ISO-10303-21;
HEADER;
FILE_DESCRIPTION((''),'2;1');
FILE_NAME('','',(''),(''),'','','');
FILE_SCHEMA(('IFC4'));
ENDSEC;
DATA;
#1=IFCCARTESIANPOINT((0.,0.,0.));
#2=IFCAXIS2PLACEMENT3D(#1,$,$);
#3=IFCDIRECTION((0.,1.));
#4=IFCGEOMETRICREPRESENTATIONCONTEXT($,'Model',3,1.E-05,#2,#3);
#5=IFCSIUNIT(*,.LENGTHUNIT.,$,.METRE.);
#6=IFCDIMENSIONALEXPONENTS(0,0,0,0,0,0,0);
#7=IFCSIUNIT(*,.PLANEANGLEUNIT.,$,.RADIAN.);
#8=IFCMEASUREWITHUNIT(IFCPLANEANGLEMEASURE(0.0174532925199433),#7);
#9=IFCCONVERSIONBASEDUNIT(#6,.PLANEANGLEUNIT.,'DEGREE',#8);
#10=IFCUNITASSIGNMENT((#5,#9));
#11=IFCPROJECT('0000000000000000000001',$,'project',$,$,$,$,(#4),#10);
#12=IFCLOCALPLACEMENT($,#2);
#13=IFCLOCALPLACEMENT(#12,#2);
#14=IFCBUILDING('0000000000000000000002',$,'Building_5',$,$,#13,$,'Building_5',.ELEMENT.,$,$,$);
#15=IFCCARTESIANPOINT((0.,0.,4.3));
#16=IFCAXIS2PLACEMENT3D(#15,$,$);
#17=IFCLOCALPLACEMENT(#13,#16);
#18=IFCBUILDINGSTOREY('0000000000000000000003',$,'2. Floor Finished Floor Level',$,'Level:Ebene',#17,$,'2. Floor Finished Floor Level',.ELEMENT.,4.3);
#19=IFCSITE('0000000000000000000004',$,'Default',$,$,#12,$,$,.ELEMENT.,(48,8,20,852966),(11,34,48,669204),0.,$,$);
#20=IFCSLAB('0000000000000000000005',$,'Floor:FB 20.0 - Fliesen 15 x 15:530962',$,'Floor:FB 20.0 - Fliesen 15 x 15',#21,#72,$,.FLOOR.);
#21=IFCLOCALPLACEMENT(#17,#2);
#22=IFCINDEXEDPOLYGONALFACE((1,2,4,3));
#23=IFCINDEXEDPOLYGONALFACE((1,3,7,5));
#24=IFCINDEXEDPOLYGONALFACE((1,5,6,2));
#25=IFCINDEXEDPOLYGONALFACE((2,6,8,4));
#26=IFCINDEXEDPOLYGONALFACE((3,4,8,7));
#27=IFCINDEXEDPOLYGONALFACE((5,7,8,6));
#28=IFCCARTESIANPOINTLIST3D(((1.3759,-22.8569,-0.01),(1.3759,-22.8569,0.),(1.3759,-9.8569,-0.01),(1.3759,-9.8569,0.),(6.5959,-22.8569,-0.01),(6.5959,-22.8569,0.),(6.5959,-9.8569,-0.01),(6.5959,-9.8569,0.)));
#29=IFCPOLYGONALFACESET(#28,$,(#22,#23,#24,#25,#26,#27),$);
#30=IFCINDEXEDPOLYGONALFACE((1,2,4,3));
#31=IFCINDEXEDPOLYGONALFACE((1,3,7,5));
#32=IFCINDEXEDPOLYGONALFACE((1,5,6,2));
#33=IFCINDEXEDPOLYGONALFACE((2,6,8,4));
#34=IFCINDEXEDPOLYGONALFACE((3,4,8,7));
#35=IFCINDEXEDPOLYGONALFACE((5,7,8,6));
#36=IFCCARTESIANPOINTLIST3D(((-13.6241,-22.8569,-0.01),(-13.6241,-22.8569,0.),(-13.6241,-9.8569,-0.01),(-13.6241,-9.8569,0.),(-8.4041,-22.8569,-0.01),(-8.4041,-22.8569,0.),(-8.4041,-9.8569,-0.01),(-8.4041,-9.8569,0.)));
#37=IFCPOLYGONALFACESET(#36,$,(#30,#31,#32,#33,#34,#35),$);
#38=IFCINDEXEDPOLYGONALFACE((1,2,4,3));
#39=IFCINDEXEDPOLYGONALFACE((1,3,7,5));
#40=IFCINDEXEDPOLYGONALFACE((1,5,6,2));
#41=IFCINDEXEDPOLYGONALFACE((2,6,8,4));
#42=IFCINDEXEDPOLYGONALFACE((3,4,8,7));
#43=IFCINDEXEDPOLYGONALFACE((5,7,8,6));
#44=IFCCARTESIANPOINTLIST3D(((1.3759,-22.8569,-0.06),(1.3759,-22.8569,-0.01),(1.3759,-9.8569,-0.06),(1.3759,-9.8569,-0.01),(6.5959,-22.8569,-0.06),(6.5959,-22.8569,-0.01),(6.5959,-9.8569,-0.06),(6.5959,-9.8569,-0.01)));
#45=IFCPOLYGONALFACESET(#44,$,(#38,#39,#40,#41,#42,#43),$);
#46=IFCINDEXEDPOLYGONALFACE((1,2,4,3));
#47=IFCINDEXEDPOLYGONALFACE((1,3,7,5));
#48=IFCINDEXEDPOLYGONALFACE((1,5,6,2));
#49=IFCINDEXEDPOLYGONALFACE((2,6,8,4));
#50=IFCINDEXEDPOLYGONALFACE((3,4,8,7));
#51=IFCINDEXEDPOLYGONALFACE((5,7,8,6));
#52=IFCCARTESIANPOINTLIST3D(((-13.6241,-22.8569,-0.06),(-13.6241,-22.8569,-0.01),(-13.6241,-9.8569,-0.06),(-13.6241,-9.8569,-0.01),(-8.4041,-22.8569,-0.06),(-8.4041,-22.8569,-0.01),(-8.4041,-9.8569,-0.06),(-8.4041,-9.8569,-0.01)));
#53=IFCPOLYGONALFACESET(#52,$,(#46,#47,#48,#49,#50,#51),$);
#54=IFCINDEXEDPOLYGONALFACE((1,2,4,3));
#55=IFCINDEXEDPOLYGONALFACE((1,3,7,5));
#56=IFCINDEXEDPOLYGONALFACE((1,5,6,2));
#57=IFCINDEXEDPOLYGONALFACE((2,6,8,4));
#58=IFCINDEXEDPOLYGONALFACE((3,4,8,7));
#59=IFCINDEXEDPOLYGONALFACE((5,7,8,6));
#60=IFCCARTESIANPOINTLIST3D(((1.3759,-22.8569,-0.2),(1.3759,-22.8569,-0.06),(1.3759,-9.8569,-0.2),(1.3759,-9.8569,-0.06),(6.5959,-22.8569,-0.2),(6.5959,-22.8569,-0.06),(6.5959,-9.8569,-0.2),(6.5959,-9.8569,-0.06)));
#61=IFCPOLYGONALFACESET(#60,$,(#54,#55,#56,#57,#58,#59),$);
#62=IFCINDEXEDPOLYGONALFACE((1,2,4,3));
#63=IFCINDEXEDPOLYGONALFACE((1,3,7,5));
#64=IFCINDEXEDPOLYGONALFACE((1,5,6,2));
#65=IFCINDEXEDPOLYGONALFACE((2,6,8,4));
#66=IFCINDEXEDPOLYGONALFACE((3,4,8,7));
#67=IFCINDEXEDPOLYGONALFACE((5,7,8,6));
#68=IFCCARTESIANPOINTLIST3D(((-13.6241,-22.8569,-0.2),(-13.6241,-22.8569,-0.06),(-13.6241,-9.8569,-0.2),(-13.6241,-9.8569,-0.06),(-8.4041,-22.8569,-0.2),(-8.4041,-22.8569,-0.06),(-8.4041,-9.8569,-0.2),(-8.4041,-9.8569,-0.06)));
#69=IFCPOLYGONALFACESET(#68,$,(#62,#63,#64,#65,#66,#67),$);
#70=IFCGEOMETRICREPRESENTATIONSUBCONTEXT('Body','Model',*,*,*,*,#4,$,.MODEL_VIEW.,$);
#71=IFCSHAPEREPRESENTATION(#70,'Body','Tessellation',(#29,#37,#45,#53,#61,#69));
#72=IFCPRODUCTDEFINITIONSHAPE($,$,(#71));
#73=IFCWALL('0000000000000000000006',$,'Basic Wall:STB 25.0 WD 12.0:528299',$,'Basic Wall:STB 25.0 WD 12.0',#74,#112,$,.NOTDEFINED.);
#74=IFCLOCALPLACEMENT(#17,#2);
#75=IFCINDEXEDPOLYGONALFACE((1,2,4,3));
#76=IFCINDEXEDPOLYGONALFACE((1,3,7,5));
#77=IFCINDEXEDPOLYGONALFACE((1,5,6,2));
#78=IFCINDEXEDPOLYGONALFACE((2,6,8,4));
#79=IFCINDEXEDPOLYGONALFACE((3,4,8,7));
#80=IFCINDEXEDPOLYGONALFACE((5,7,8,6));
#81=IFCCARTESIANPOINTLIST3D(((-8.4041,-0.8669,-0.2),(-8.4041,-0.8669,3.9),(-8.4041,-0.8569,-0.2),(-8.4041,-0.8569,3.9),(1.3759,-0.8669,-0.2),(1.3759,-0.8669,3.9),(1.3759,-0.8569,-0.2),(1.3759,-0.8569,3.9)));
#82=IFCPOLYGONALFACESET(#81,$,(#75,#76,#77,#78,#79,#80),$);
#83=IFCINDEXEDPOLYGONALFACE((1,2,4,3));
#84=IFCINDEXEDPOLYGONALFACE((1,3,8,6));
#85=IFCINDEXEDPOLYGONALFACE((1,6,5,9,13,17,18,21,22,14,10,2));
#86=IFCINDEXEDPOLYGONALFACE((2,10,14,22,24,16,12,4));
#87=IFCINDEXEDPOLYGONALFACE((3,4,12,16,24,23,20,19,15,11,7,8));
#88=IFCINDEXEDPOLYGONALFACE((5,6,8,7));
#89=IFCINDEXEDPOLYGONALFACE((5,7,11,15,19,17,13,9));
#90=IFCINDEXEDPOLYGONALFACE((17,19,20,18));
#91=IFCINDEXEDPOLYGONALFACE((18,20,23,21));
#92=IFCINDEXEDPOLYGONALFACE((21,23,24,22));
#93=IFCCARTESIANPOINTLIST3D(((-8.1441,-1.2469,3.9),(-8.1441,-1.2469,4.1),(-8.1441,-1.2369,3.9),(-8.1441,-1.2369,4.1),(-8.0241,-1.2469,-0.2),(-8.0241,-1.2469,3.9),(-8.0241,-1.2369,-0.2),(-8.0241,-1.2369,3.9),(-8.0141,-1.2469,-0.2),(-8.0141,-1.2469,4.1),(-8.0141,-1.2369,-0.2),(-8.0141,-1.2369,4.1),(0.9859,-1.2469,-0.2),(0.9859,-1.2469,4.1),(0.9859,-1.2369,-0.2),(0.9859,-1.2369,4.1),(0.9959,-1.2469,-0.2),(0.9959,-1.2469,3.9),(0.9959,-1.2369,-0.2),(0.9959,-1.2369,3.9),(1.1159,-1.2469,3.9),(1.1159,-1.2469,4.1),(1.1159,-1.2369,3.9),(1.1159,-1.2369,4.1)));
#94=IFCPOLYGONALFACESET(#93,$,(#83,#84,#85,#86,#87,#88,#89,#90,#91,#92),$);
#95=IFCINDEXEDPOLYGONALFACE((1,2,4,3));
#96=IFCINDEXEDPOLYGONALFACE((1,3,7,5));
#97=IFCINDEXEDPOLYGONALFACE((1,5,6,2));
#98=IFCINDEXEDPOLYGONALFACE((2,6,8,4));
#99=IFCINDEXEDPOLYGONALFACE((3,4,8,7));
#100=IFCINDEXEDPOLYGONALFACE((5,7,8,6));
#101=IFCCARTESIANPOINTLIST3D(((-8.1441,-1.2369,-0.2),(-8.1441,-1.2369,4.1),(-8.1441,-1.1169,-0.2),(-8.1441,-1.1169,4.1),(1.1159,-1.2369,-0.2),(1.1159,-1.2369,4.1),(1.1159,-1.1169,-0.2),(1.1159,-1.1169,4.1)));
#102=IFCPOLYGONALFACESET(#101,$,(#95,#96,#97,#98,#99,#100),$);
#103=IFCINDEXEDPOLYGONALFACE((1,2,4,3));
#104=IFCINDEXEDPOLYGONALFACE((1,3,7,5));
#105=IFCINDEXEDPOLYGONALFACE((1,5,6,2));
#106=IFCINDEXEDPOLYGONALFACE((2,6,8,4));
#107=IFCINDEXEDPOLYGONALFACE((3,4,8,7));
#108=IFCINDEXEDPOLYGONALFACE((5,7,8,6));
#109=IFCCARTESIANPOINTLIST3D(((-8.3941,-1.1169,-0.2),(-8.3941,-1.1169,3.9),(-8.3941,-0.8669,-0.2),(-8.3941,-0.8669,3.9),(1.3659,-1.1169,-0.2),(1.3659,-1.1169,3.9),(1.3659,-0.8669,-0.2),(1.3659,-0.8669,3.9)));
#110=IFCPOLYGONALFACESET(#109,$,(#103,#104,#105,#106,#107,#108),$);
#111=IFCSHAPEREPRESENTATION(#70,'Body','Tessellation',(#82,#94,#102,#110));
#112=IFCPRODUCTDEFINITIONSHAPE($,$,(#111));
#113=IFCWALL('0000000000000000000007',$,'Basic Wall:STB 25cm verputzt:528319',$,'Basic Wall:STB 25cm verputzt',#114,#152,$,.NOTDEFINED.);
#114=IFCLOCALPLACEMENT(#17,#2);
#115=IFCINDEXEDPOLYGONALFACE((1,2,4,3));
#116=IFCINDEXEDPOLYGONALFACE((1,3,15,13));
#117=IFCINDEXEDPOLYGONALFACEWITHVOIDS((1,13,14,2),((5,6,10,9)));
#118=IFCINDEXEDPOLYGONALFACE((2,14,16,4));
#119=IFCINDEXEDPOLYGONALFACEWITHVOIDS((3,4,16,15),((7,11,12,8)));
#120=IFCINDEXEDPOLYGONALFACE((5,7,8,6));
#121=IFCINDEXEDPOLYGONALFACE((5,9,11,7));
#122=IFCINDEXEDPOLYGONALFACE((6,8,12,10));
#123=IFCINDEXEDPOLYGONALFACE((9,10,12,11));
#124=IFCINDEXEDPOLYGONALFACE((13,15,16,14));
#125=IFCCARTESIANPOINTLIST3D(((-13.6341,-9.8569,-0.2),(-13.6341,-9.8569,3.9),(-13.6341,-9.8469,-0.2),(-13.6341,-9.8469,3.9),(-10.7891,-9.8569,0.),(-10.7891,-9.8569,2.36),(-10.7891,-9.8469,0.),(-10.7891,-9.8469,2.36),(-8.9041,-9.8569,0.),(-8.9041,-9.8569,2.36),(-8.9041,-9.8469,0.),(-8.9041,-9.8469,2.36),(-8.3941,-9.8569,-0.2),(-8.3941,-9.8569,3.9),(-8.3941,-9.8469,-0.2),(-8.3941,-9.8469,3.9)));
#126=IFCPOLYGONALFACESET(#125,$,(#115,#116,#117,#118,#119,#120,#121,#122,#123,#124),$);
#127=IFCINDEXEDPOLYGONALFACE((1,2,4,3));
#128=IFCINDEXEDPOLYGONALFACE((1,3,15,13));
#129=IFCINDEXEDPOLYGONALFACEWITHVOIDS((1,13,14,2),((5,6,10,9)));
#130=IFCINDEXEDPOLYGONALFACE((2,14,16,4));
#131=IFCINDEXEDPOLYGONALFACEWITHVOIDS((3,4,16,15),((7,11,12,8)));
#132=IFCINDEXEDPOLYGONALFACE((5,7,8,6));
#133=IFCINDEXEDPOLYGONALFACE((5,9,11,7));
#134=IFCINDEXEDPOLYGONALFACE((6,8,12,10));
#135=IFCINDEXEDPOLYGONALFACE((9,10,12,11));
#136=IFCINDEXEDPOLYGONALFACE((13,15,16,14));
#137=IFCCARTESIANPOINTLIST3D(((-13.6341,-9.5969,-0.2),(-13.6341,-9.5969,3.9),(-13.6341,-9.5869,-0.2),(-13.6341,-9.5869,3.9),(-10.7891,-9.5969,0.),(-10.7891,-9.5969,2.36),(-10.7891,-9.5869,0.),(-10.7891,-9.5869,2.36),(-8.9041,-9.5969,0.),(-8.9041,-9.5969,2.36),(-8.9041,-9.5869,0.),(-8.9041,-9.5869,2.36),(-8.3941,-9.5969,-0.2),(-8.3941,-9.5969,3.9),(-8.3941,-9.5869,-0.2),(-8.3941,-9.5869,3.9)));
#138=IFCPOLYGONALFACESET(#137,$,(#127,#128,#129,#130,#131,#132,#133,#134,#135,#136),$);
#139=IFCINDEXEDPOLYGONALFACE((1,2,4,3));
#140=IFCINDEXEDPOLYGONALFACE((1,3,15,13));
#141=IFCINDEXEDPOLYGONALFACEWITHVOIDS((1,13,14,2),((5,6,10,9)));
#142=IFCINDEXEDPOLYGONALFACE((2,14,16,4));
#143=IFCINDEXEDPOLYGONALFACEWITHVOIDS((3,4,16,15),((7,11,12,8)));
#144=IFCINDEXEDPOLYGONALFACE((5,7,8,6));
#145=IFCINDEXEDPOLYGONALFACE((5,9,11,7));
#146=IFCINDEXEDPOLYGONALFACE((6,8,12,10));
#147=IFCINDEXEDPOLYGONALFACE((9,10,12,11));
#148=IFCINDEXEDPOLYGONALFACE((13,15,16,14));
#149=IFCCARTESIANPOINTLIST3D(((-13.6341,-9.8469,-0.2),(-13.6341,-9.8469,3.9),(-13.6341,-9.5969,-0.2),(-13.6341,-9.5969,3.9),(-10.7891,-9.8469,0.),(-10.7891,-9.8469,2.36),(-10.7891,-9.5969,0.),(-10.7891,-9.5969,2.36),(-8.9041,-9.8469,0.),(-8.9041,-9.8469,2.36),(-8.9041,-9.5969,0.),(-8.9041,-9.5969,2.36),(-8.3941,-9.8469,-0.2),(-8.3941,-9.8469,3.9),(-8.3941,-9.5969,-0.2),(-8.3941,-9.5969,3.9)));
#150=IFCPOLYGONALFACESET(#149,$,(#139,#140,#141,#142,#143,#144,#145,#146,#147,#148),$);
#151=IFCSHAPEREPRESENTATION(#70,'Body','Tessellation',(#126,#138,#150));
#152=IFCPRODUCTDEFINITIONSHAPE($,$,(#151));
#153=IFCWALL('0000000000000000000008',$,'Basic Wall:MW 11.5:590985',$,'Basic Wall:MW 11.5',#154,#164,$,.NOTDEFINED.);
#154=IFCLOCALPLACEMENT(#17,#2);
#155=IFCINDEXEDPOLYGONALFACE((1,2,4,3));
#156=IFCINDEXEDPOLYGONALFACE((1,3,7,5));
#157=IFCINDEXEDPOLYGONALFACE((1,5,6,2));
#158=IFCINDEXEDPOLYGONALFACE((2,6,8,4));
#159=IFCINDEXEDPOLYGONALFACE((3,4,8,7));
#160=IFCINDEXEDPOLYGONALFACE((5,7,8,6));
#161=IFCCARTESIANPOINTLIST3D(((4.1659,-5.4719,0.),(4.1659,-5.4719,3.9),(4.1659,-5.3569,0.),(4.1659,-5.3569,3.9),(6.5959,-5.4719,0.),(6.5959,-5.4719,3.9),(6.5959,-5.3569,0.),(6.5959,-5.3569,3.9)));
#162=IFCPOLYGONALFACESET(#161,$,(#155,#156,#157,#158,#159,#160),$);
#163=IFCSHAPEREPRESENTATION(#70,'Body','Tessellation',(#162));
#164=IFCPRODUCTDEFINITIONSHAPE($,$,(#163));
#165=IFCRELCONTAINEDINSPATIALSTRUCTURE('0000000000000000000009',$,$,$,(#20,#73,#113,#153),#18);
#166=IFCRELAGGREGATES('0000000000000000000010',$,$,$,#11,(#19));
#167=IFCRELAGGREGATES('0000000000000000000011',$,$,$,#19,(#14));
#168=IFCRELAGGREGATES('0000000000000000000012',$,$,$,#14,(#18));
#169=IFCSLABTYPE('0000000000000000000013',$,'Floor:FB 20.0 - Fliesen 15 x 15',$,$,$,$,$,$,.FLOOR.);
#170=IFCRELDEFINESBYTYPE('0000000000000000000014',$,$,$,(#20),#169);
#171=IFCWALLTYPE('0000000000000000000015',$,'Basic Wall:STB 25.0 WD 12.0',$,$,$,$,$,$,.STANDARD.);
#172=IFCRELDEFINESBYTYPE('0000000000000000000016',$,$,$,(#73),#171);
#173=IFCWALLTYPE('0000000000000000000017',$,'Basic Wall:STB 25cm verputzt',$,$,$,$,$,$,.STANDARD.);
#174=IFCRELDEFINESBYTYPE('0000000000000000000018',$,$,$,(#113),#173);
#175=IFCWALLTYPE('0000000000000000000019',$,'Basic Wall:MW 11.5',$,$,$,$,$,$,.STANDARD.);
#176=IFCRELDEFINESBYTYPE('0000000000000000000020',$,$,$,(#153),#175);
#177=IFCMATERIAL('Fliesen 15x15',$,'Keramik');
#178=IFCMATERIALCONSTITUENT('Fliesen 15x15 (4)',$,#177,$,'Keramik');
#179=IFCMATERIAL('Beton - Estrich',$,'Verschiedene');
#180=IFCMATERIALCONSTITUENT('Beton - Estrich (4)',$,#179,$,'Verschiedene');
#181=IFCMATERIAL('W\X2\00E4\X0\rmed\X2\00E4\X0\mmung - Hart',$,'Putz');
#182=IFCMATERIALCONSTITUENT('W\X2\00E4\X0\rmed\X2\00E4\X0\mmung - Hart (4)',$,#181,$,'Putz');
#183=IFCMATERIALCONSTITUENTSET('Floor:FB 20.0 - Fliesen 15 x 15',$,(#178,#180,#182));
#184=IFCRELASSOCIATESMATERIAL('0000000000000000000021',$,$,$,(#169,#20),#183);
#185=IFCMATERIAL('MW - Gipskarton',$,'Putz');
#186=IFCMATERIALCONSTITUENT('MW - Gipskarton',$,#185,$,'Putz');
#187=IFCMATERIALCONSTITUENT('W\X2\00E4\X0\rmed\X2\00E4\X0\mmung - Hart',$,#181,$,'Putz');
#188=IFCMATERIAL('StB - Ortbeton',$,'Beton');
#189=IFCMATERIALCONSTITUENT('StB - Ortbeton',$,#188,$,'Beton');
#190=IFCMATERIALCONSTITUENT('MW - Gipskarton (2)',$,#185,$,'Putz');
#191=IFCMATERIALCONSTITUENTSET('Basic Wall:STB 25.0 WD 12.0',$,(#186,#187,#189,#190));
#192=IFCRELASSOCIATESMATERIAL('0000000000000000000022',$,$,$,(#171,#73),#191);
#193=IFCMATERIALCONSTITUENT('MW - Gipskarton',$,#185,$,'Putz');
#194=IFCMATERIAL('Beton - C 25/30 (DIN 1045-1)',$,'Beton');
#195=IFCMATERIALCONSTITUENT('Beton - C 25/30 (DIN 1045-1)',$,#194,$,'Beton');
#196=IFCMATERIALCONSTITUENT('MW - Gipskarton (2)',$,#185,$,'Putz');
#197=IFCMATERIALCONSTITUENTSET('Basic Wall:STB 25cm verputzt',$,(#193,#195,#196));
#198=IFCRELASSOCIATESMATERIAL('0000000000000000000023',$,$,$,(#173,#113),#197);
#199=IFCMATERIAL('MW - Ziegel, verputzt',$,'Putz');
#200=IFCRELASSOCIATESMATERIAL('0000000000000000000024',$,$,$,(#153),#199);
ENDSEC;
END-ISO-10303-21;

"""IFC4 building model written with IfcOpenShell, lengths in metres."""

from ifc_helpers import new_model, entity, si_unit, converted_unit, direction, frame, origin, place, context, subcontext, project, spatial, indexed_curve, outline, extrude, material, constituent, constituent_set, type_object, element, save


model = new_model("IFC4")

# Units and contexts
model_context = context("Model", 3, precision=1e-05, world=origin(), true_north=direction((0.0, 1.0)))
body_context = subcontext(model_context, "Body", "Model", "MODEL_VIEW")
ifc_project = project(units=[si_unit("LENGTHUNIT", "METRE"), converted_unit("PLANEANGLEUNIT", "DEGREE", entity("IfcPlaneAngleMeasure", 0.0174532925199433), si_unit("PLANEANGLEUNIT", "RADIAN"), dimensions=[0, 0, 0, 0, 0, 0, 0])], contexts=[model_context])

# Site, building, storey
site_placement = place(None, origin())
site = spatial("IfcSite", under=ifc_project, at=site_placement, Name="Default", CompositionType="ELEMENT", RefLatitude=(48, 8, 20, 852966), RefLongitude=(11, 34, 48, 669204), RefElevation=0.0)
building_placement = place(site_placement, origin())
building = spatial("IfcBuilding", under=site, at=building_placement, Name="Building_5", LongName="Building_5", CompositionType="ELEMENT")
storey_placement = place(building_placement, frame((0.0, 0.0, 4.3)))
storey = spatial("IfcBuildingStorey", under=building, at=storey_placement, Name="2. Floor Finished Floor Level", ObjectType="Level:Ebene", LongName="2. Floor Finished Floor Level", CompositionType="ELEMENT", Elevation=4.3)

# Shared definitions
ifc_material_1 = material(Name="MW - Gipskarton", Category="Putz")

# Slab
ifc_material_2 = material(Name="Fliesen 15x15", Category="Keramik")
ifc_constituent_1 = constituent(ifc_material_2, Name="Fliesen 15x15 (4)", Category="Keramik")
ifc_material_3 = material(Name="Beton - Estrich", Category="Verschiedene")
ifc_constituent_2 = constituent(ifc_material_3, Name="Beton - Estrich (4)", Category="Verschiedene")
ifc_material_4 = material(Name="Wärmedämmung - Hart", Category="Putz")
ifc_constituent_3 = constituent(ifc_material_4, Name="Wärmedämmung - Hart (4)", Category="Putz")
ifc_constituent_set_1 = constituent_set(constituents=[ifc_constituent_1, ifc_constituent_2, ifc_constituent_3], Name="Floor:FB 20.0 - Fliesen 15 x 15")
slab_type_1 = type_object("IfcSlabType", Name="Floor:FB 20.0 - Fliesen 15 x 15", PredefinedType="FLOOR", material=ifc_constituent_set_1)
slab_1_placement = place(storey_placement, origin())
element("IfcSlab", 1, at=slab_1_placement, inside=storey, type_object=slab_type_1, material=ifc_constituent_set_1, Name="Floor:FB 20.0 - Fliesen 15 x 15:530962", ObjectType="Floor:FB 20.0 - Fliesen 15 x 15", PredefinedType="FLOOR", context=body_context, shape_type="SweptSolid", body=[
    extrude(outline(indexed_curve([(-2.61, -6.5), (2.61, -6.5), (2.61, 6.5), (-2.61, 6.5), (-2.61, -6.5)], self_intersect=False)), frame((3.9859, -16.3569, -0.01), z_axis=(0.0, 0.0, 1.0), x_axis=(-1.0, 0.0, 0.0)), (0.0, 0.0, 1.0), 0.01),
    extrude(outline(indexed_curve([(-6.5, -2.61), (6.5, -2.61), (6.5, 2.61), (-6.5, 2.61), (-6.5, -2.61)], self_intersect=False)), frame((-11.0141, -16.3569, -0.01), z_axis=(0.0, 0.0, 1.0), x_axis=(0.0, 1.0, 0.0)), (0.0, 0.0, 1.0), 0.01),
    extrude(outline(indexed_curve([(-2.61, -6.5), (2.61, -6.5), (2.61, 6.5), (-2.61, 6.5), (-2.61, -6.5)], self_intersect=False)), frame((3.9859, -16.3569, -0.06), z_axis=(0.0, 0.0, 1.0), x_axis=(-1.0, 0.0, 0.0)), (0.0, 0.0, 1.0), 0.05),
    extrude(outline(indexed_curve([(-6.5, -2.61), (6.5, -2.61), (6.5, 2.61), (-6.5, 2.61), (-6.5, -2.61)], self_intersect=False)), frame((-11.0141, -16.3569, -0.06), z_axis=(0.0, 0.0, 1.0), x_axis=(0.0, 1.0, 0.0)), (0.0, 0.0, 1.0), 0.05),
    extrude(outline(indexed_curve([(-2.61, -6.5), (2.61, -6.5), (2.61, 6.5), (-2.61, 6.5), (-2.61, -6.5)], self_intersect=False)), frame((3.9859, -16.3569, -0.2), z_axis=(0.0, 0.0, 1.0), x_axis=(-1.0, 0.0, 0.0)), (0.0, 0.0, 1.0), 0.14),
    extrude(outline(indexed_curve([(-6.5, -2.61), (6.5, -2.61), (6.5, 2.61), (-6.5, 2.61), (-6.5, -2.61)], self_intersect=False)), frame((-11.0141, -16.3569, -0.2), z_axis=(0.0, 0.0, 1.0), x_axis=(0.0, 1.0, 0.0)), (0.0, 0.0, 1.0), 0.14),
])

# Wall
ifc_constituent_4 = constituent(ifc_material_1, Name="MW - Gipskarton", Category="Putz")
ifc_constituent_5 = constituent(ifc_material_4, Name="Wärmedämmung - Hart", Category="Putz")
ifc_material_5 = material(Name="StB - Ortbeton", Category="Beton")
ifc_constituent_6 = constituent(ifc_material_5, Name="StB - Ortbeton", Category="Beton")
ifc_constituent_7 = constituent(ifc_material_1, Name="MW - Gipskarton (2)", Category="Putz")
ifc_constituent_set_2 = constituent_set(constituents=[ifc_constituent_4, ifc_constituent_5, ifc_constituent_6, ifc_constituent_7], Name="Basic Wall:STB 25.0 WD 12.0")
wall_type_1 = type_object("IfcWallType", Name="Basic Wall:STB 25.0 WD 12.0", PredefinedType="STANDARD", material=ifc_constituent_set_2)
wall_1_placement = place(storey_placement, frame((-8.4041, -1.0519, -0.2)))
element("IfcWall", 2, at=wall_1_placement, inside=storey, type_object=wall_type_1, material=ifc_constituent_set_2, Name="Basic Wall:STB 25.0 WD 12.0:528299", ObjectType="Basic Wall:STB 25.0 WD 12.0", PredefinedType="NOTDEFINED", context=body_context, shape_type="SweptSolid", body=[
    extrude(outline(indexed_curve([(-0.005, -4.89), (0.005, -4.89), (0.005, 4.89), (-0.005, 4.89), (-0.005, -4.89)], self_intersect=False)), frame((4.89, 0.19, 0.0), z_axis=(0.0, 0.0, 1.0), x_axis=(0.0, -1.0, 0.0)), (0.0, 0.0, 1.0), 4.1),
    extrude(outline(indexed_curve([(-2.8, 4.51), (-2.8, 4.5), (-2.8, -4.5), (-2.8, -4.51), (1.3, -4.51), (1.3, -4.63), (1.5, -4.63), (1.5, -4.5), (1.5, 4.5), (1.5, 4.63), (1.3, 4.63), (1.3, 4.51), (-2.8, 4.51)], self_intersect=False)), frame((4.89, -0.195, 2.8), z_axis=(0.0, -1.0, 0.0), x_axis=(0.0, 0.0, 1.0)), (0.0, 0.0, -1.0), 0.01),
    extrude(outline(indexed_curve([(-4.63, -0.06), (4.63, -0.06), (4.63, 0.06), (-4.63, 0.06), (-4.63, -0.06)], self_intersect=False)), frame((4.89, -0.125, 0.0)), (0.0, 0.0, 1.0), 4.3),
    extrude(outline(indexed_curve([(-4.88, -0.125), (4.88, -0.125), (4.88, 0.125), (-4.88, 0.125), (-4.88, -0.125)], self_intersect=False)), frame((4.89, 0.06, 0.0)), (0.0, 0.0, 1.0), 4.1),
])

# Wall, opening
ifc_constituent_8 = constituent(ifc_material_1, Name="MW - Gipskarton", Category="Putz")
ifc_material_6 = material(Name="Beton - C 25/30 (DIN 1045-1)", Category="Beton")
ifc_constituent_9 = constituent(ifc_material_6, Name="Beton - C 25/30 (DIN 1045-1)", Category="Beton")
ifc_constituent_10 = constituent(ifc_material_1, Name="MW - Gipskarton (2)", Category="Putz")
ifc_constituent_set_3 = constituent_set(constituents=[ifc_constituent_8, ifc_constituent_9, ifc_constituent_10], Name="Basic Wall:STB 25cm verputzt")
wall_type_2 = type_object("IfcWallType", Name="Basic Wall:STB 25cm verputzt", PredefinedType="STANDARD", material=ifc_constituent_set_3)
wall_2_placement = place(storey_placement, frame((-13.6241, -9.7219, -0.2)))
wall_2 = element("IfcWall", 3, at=wall_2_placement, inside=storey, type_object=wall_type_2, material=ifc_constituent_set_3, Name="Basic Wall:STB 25cm verputzt:528319", ObjectType="Basic Wall:STB 25cm verputzt", PredefinedType="NOTDEFINED", context=body_context, shape_type="SweptSolid", body=[
    extrude(outline(indexed_curve([(-2.05, -2.62), (2.05, -2.62), (2.05, 2.62), (-2.05, 2.62), (-2.05, -2.62)], self_intersect=False), holes=[indexed_curve([(-1.85, 0.225), (-1.85, 2.11), (0.51, 2.11), (0.51, 0.225), (-1.85, 0.225)], self_intersect=False)]), frame((2.61, -0.135, 2.05), z_axis=(0.0, 1.0, 0.0), x_axis=(0.0, 0.0, 1.0)), (0.0, 0.0, 1.0), 0.01),
    extrude(outline(indexed_curve([(-2.05, -2.62), (2.05, -2.62), (2.05, 2.62), (-2.05, 2.62), (-2.05, -2.62)], self_intersect=False), holes=[indexed_curve([(-1.85, 0.225), (-1.85, 2.11), (0.51, 2.11), (0.51, 0.225), (-1.85, 0.225)], self_intersect=False)]), frame((2.61, 0.125, 2.05), z_axis=(0.0, 1.0, 0.0), x_axis=(0.0, 0.0, 1.0)), (0.0, 0.0, 1.0), 0.01),
    extrude(outline(indexed_curve([(-2.05, -2.62), (2.05, -2.62), (2.05, 2.62), (-2.05, 2.62), (-2.05, -2.62)], self_intersect=False), holes=[indexed_curve([(-1.85, 0.225), (-1.85, 2.11), (0.51, 2.11), (0.51, 0.225), (-1.85, 0.225)], self_intersect=False)]), frame((2.61, -0.125, 2.05), z_axis=(0.0, 1.0, 0.0), x_axis=(0.0, 0.0, 1.0)), (0.0, 0.0, 1.0), 0.25),
])
opening_1_placement = place(wall_2_placement, frame((4.72, 0.135, 0.2)))
element("IfcOpeningElement", 4, at=opening_1_placement, cuts=wall_2, PredefinedType="OPENING", context=body_context, shape_type="SweptSolid", body=[
    extrude(outline(indexed_curve([(0.0, 1.885), (0.0, 0.0), (2.36, 0.0), (2.36, 1.885), (0.0, 1.885)], self_intersect=False)), frame((0.0, 0.0, 0.0), z_axis=(0.0, -1.0, 0.0), x_axis=(0.0, 0.0, 1.0)), (0.0, 0.0, 1.0), 0.27),
])

# Wall
ifc_material_7 = material(Name="MW - Ziegel, verputzt", Category="Putz")
wall_type_3 = type_object("IfcWallType", Name="Basic Wall:MW 11.5", PredefinedType="STANDARD")
wall_3_placement = place(storey_placement, frame((4.1659, -5.4144, 0.0)))
element("IfcWall", 5, at=wall_3_placement, inside=storey, type_object=wall_type_3, material=ifc_material_7, Name="Basic Wall:MW 11.5:590985", ObjectType="Basic Wall:MW 11.5", PredefinedType="NOTDEFINED", context=body_context, shape_type="SweptSolid", body=[
    extrude(outline(indexed_curve([(2.43, 0.0575), (0.0, 0.0575), (0.0, -0.0575), (2.43, -0.0575), (2.43, 0.0575)], self_intersect=False)), origin(), (0.0, 0.0, 1.0), 3.9),
])

save(model, "model.ifc")
